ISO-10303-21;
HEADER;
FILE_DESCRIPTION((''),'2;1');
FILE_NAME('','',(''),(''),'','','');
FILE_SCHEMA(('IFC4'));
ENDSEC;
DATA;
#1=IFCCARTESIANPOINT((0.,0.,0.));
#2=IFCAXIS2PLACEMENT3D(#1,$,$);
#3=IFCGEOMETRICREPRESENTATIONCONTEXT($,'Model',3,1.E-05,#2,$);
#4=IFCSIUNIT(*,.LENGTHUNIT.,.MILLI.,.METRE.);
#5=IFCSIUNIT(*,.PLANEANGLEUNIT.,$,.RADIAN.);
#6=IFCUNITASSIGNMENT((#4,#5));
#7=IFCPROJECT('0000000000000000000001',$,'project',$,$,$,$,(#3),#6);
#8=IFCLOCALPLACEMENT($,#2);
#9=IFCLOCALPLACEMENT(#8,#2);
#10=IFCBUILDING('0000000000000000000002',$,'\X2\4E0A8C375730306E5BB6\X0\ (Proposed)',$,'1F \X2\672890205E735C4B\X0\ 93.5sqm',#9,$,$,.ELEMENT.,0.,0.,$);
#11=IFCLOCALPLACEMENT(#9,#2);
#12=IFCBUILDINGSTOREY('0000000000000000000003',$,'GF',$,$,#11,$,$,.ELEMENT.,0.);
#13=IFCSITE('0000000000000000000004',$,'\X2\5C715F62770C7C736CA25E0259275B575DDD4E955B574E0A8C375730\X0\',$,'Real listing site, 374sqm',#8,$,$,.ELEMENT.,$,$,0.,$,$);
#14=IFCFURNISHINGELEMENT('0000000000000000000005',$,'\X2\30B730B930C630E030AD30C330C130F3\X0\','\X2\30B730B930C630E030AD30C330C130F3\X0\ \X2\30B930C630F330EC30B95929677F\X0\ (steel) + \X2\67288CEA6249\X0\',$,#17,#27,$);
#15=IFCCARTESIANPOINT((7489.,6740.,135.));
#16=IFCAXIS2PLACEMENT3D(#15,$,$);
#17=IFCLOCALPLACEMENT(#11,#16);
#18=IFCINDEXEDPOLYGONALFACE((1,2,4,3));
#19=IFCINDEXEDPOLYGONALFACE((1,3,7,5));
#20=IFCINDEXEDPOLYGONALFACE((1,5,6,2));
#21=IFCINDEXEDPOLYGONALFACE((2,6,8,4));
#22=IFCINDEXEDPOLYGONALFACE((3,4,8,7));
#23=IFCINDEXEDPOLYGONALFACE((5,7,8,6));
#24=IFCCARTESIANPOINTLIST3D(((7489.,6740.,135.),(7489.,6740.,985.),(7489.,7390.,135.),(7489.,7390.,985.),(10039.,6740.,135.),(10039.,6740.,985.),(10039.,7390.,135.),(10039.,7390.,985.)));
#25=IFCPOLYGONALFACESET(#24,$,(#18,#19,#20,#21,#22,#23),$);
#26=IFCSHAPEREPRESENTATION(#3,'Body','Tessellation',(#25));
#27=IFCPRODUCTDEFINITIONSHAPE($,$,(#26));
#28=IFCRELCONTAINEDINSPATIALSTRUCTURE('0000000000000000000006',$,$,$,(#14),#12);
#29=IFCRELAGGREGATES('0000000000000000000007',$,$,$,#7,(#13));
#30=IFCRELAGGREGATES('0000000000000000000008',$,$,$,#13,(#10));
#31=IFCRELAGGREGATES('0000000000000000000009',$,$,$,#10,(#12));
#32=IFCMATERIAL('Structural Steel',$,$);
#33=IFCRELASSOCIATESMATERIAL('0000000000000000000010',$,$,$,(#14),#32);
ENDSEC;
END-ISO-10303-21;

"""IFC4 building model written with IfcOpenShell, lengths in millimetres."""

from ifc_helpers import new_model, si_unit, frame, frame_2d, origin, place, context, project, spatial, rectangle, extrude, material, element, save


model = new_model("IFC4")

# Units and contexts
model_context = context("Model", 3, precision=1e-05, world=origin())
ifc_project = project(units=[si_unit("LENGTHUNIT", "METRE", prefix="MILLI"), si_unit("PLANEANGLEUNIT", "RADIAN")], contexts=[model_context])

# Site, building, storey
site_placement = place(None, origin())
site = spatial("IfcSite", under=ifc_project, at=site_placement, Name="山形県米沢市大字川井字上谷地", ObjectType="Real listing site, 374sqm", CompositionType="ELEMENT", RefElevation=0.0)
building_placement = place(site_placement, origin())
building = spatial("IfcBuilding", under=site, at=building_placement, Name="上谷地の家 (Proposed)", ObjectType="1F 木造平屋 93.5sqm", CompositionType="ELEMENT", ElevationOfRefHeight=0.0, ElevationOfTerrain=0.0)
storey_placement = place(building_placement, origin())
storey = spatial("IfcBuildingStorey", under=building, at=storey_placement, Name="GF", CompositionType="ELEMENT", Elevation=0.0)

# Shared definitions
ifc_material_1 = material(Name="Structural Steel")

# Furnishing element
furnishing_1_placement = place(storey_placement, frame((7489.0, 6740.0, 135.0)))
element("IfcFurnishingElement", 1, at=furnishing_1_placement, inside=storey, material=ifc_material_1, Name="システムキッチン", Description="システムキッチン ステンレス天板 (steel) + 木質扉", context=model_context, shape_type="SweptSolid", body=[
    extrude(rectangle(XDim=2550.0, YDim=650.0, at=frame_2d((1275.0, 325.0))), frame((7489.0, 6740.0, 135.0)), (0.0, 0.0, 1.0), 850.0),
])

save(model, "model.ifc")
